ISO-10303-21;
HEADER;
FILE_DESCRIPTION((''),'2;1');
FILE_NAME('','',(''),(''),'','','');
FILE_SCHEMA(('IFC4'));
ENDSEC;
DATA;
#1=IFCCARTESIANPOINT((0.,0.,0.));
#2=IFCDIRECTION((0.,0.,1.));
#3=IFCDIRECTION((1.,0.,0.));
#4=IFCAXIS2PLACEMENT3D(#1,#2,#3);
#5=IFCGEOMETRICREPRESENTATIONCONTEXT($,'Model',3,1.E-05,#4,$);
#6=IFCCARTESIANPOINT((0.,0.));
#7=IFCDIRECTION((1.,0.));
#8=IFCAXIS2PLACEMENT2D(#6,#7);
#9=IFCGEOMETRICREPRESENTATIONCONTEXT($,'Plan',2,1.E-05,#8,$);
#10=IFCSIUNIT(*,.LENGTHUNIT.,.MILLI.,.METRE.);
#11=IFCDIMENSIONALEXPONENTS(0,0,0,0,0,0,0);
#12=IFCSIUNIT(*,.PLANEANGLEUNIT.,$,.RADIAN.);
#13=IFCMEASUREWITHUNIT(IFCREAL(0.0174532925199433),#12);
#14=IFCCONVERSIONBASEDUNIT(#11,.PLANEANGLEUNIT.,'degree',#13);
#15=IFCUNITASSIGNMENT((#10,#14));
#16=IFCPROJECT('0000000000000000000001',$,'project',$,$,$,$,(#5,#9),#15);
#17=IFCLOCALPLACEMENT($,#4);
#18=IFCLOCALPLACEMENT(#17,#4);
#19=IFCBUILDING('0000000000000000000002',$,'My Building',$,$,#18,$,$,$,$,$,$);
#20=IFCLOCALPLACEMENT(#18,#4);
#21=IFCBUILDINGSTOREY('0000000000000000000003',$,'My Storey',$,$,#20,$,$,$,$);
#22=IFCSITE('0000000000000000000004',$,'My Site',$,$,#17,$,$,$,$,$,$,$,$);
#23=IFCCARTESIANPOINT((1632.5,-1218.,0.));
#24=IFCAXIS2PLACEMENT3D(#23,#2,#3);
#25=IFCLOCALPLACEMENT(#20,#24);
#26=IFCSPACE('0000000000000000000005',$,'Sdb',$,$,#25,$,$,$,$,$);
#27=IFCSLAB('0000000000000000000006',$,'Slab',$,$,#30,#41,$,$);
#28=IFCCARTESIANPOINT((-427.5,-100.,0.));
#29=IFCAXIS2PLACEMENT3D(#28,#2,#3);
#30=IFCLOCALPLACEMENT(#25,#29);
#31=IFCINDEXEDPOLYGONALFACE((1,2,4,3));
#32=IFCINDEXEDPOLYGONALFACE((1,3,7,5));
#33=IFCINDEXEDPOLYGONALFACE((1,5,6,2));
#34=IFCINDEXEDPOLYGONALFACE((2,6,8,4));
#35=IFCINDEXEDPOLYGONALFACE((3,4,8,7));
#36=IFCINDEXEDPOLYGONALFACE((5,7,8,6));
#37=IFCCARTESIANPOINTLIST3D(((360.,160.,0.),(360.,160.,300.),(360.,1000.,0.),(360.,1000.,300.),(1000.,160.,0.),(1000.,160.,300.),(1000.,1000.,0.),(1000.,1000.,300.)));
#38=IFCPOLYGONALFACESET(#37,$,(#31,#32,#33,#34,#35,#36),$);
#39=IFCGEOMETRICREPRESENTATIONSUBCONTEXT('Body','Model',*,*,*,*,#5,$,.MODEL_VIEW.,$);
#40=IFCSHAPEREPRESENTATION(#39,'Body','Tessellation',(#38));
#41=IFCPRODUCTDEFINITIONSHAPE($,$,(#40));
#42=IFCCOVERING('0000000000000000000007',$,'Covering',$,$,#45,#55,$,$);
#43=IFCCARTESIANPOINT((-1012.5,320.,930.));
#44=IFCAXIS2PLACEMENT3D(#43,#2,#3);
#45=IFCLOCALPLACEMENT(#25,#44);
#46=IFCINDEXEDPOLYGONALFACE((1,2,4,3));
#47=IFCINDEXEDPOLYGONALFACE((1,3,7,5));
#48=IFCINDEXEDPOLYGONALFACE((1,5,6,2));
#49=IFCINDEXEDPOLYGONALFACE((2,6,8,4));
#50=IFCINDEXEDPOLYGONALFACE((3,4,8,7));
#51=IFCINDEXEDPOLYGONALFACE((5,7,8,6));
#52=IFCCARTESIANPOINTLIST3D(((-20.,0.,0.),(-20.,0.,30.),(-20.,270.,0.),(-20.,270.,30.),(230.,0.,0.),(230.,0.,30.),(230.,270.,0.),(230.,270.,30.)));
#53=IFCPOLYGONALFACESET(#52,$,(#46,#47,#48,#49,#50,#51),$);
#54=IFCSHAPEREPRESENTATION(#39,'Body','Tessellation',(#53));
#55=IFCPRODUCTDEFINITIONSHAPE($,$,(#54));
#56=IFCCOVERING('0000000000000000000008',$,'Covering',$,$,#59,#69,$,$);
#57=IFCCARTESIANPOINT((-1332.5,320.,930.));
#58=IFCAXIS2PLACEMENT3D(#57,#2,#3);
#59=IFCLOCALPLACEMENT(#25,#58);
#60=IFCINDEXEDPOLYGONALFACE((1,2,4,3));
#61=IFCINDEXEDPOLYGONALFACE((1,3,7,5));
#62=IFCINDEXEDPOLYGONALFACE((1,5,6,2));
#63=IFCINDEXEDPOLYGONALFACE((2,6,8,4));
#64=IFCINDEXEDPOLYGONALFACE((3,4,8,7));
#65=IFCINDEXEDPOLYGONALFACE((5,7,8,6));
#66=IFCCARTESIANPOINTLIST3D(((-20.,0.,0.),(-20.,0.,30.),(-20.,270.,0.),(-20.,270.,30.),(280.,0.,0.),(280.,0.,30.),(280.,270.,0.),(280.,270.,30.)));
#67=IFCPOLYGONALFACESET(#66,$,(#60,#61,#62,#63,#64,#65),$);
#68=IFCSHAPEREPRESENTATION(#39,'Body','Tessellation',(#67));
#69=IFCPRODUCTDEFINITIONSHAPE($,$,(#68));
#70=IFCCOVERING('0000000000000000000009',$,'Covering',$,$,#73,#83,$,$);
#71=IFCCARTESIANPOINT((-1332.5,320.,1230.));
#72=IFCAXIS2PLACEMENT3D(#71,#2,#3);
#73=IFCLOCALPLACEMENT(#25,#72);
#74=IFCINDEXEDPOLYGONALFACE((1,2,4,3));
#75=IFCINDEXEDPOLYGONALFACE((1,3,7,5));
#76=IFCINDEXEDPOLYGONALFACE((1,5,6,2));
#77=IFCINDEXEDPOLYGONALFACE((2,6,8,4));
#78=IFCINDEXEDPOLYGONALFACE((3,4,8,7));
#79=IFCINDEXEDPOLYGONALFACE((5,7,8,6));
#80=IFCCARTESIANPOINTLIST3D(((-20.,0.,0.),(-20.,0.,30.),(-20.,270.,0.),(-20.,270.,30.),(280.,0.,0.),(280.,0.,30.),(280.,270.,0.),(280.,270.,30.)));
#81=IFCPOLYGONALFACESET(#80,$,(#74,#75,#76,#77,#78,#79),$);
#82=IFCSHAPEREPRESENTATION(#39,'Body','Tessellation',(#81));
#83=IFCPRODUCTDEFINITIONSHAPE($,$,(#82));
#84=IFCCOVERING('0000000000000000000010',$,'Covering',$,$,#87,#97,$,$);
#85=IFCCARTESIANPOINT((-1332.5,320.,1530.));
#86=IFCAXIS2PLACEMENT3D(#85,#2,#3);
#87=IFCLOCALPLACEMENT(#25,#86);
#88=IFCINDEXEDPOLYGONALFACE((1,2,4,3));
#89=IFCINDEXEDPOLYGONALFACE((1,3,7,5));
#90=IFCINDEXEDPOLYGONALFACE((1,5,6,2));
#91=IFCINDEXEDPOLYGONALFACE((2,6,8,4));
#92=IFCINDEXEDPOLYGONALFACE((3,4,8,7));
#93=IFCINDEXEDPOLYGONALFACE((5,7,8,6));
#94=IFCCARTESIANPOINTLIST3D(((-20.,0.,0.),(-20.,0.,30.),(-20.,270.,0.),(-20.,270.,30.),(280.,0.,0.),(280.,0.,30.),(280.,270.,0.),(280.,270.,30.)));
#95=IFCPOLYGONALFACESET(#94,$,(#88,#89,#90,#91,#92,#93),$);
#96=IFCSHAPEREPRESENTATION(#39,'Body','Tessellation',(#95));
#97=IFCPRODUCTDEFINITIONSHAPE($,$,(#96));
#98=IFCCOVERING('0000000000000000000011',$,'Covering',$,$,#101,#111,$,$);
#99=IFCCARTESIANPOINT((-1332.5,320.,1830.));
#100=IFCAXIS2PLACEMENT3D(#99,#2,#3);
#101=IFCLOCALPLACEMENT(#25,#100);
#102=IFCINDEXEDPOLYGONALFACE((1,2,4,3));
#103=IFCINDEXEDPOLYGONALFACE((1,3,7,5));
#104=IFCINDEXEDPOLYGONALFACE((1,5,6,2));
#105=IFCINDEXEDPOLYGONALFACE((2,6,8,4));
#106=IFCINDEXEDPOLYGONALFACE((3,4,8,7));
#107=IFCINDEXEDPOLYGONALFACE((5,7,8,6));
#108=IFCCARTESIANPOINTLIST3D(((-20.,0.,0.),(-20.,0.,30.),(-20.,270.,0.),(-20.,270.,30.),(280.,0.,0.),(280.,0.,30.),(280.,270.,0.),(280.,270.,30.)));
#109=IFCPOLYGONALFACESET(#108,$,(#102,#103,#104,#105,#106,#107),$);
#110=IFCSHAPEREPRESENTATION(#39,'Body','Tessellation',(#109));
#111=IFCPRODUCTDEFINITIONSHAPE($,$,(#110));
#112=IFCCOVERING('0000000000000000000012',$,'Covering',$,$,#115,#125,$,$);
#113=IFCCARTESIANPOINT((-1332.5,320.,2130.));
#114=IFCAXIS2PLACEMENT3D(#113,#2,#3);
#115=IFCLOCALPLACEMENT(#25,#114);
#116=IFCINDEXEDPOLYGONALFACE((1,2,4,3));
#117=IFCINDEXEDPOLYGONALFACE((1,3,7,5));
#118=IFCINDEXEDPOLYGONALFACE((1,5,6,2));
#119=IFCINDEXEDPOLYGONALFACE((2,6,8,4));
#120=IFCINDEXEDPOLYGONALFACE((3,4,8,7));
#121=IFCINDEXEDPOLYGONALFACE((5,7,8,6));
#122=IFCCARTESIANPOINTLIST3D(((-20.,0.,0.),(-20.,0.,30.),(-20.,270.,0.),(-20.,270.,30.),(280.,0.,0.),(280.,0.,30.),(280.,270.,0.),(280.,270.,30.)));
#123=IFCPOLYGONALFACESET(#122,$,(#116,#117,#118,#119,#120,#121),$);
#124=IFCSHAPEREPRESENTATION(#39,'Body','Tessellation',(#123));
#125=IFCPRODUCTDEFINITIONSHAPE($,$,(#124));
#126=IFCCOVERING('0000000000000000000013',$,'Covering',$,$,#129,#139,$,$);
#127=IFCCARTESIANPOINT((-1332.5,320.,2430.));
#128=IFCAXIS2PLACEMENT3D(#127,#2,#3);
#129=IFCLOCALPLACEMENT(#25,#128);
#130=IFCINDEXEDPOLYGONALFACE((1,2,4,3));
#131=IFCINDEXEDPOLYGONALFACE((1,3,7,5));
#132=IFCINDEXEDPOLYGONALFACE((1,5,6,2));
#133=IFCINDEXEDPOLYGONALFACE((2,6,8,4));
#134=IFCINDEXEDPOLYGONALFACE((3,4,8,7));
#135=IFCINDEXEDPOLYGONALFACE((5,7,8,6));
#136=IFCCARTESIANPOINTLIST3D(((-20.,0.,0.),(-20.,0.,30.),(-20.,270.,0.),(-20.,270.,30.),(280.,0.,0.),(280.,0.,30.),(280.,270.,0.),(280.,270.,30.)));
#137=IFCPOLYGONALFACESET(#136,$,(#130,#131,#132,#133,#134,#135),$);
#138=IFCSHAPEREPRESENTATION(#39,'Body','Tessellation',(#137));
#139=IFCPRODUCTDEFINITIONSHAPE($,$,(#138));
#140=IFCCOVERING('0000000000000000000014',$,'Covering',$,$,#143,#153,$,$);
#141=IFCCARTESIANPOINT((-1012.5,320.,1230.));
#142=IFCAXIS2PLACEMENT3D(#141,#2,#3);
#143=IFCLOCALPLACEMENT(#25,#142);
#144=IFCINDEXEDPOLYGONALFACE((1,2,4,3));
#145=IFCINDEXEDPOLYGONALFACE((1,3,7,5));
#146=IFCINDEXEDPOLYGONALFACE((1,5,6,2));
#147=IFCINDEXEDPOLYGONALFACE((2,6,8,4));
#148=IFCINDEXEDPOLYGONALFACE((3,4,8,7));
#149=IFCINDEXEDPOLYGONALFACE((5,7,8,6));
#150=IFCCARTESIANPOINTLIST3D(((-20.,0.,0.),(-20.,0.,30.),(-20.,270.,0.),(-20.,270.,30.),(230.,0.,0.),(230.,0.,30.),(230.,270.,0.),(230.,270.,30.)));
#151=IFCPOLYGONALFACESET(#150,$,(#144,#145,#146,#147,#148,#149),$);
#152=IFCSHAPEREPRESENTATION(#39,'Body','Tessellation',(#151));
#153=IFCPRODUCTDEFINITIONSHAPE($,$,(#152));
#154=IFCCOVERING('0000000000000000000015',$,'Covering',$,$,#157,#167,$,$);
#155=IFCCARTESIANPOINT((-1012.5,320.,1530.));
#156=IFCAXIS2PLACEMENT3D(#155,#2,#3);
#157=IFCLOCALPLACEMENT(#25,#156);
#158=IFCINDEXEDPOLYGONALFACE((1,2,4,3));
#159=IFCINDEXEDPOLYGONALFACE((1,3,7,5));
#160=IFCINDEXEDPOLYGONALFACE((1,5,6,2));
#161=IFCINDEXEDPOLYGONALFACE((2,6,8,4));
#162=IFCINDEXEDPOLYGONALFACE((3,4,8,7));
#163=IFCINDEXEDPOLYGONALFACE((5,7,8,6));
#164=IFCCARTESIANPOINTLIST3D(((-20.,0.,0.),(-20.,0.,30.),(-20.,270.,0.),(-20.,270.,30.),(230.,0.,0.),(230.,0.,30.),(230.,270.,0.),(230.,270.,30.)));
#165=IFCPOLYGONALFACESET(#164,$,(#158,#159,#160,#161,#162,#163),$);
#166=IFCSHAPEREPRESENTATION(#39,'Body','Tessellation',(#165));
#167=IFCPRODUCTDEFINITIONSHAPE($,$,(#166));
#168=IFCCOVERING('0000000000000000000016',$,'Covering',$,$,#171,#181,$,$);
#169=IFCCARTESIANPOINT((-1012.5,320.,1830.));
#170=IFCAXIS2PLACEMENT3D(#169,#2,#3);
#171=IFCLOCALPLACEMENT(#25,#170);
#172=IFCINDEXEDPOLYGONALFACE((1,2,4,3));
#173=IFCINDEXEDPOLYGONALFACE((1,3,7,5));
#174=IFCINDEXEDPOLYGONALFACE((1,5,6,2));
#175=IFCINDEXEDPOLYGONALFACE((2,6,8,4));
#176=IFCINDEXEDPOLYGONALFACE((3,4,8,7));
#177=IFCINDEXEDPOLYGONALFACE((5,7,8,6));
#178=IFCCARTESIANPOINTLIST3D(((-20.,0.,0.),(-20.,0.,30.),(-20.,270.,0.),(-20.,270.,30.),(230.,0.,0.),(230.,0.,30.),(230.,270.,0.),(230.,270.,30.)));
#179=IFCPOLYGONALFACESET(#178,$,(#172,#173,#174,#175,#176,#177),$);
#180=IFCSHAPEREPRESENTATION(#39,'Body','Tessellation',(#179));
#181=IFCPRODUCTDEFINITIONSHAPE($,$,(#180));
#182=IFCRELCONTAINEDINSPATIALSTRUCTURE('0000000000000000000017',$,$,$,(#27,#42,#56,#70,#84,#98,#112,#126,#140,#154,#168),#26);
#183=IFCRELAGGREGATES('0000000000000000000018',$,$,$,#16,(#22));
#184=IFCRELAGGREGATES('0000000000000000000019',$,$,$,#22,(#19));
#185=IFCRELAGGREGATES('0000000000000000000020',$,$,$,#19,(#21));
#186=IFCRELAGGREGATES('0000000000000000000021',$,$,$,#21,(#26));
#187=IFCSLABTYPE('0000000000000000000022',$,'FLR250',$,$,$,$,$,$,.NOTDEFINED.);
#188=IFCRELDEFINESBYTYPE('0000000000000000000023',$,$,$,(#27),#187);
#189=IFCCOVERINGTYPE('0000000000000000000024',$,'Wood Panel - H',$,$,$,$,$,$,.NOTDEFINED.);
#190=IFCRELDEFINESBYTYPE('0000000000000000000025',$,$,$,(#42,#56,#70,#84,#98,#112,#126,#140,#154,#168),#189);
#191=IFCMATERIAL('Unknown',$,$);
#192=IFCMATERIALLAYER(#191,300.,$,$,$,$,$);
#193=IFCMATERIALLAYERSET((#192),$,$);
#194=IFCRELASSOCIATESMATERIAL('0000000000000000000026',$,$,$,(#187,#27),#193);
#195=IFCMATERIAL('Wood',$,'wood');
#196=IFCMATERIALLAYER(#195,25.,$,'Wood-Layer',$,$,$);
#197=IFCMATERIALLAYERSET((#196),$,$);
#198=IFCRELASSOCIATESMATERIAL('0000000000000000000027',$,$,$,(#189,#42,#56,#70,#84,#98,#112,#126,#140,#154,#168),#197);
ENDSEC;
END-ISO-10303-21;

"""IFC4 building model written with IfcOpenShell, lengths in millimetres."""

from ifc_helpers import new_model, entity, si_unit, converted_unit, frame, origin_with_axes, origin_2d_with_axis, place, context, subcontext, project, spatial, line, indexed_curve, outline, extrude, material, layer, layer_set, layer_usage, type_object, element, save


model = new_model("IFC4")

# Units and contexts
model_context = context("Model", 3, precision=1e-05, world=origin_with_axes())
plan_context = context("Plan", 2, precision=1e-05, world=origin_2d_with_axis())
body_context = subcontext(model_context, "Body", "Model", "MODEL_VIEW")
ifc_project = project(units=[si_unit("LENGTHUNIT", "METRE", prefix="MILLI"), converted_unit("PLANEANGLEUNIT", "degree", entity("IfcReal", 0.0174532925199433), si_unit("PLANEANGLEUNIT", "RADIAN"), dimensions=[0, 0, 0, 0, 0, 0, 0])], contexts=[model_context, plan_context])

# Site, building, storey, space
site_placement = place(None, origin_with_axes())
site = spatial("IfcSite", under=ifc_project, at=site_placement, Name="My Site")
building_placement = place(site_placement, origin_with_axes())
building = spatial("IfcBuilding", under=site, at=building_placement, Name="My Building")
storey_placement = place(building_placement, origin_with_axes())
storey = spatial("IfcBuildingStorey", under=building, at=storey_placement, Name="My Storey")
space_1_placement = place(storey_placement, frame((1632.5, -1218.0, 0.0), z_axis=(0.0, 0.0, 1.0), x_axis=(1.0, 0.0, 0.0)))
space_1 = spatial("IfcSpace", under=storey, at=space_1_placement, Name="Sdb")

# Slab
ifc_material_1 = material(Name="Unknown")
ifc_layer_1 = layer(ifc_material_1, 300.0)
ifc_layer_set_1 = layer_set([ifc_layer_1])
ifc_layer_usage_1 = layer_usage(ifc_layer_set_1, "AXIS3", "POSITIVE", 0.0)
slab_type = type_object("IfcSlabType", Name="FLR250", PredefinedType="NOTDEFINED", material=ifc_layer_set_1)
slab_placement = place(space_1_placement, frame((-427.5, -100.0, 0.0), z_axis=(0.0, 0.0, 1.0), x_axis=(1.0, 0.0, 0.0)))
element("IfcSlab", 1, at=slab_placement, inside=space_1, type_object=slab_type, material=ifc_layer_usage_1, Name="Slab", context=body_context, shape_type="SweptSolid", body=[
    extrude(outline(indexed_curve([(1000.0, 160.0), (360.0, 160.0), (360.0, 1000.0), (1000.0, 1000.0)], segments=[line(4, 1), line(1, 2), line(2, 3), line(3, 4)], self_intersect=False)), None, (0.0, 0.0, 1.0), 300.0),
])

# Coverings
ifc_material_2 = material(Name="Wood", Category="wood")
ifc_layer_2 = layer(ifc_material_2, 25.0, Name="Wood-Layer")
ifc_layer_set_2 = layer_set([ifc_layer_2])
ifc_layer_usage_2 = layer_usage(ifc_layer_set_2, "AXIS3", "POSITIVE", 0.0)
covering_type_1 = type_object("IfcCoveringType", Name="Wood Panel - H", PredefinedType="NOTDEFINED", material=ifc_layer_set_2)
covering_1_placement = place(space_1_placement, frame((-1012.5, 320.0, 930.0), z_axis=(0.0, 0.0, 1.0), x_axis=(1.0, 0.0, 0.0)))
element("IfcCovering", 2, at=covering_1_placement, inside=space_1, type_object=covering_type_1, material=ifc_layer_usage_2, Name="Covering", context=body_context, shape_type="SweptSolid", body=[
    extrude(outline(indexed_curve([(-20.0, 0.0), (-20.0, 270.0), (230.0, 270.0), (230.0, 0.0)], segments=[line(4, 1), line(1, 2), line(2, 3), line(3, 4)], self_intersect=False)), None, (0.0, 0.0, 1.0), 30.0),
])
ifc_layer_usage_3 = layer_usage(ifc_layer_set_2, "AXIS3", "POSITIVE", 0.0)
covering_2_placement = place(space_1_placement, frame((-1332.5, 320.0, 930.0), z_axis=(0.0, 0.0, 1.0), x_axis=(1.0, 0.0, 0.0)))
element("IfcCovering", 3, at=covering_2_placement, inside=space_1, type_object=covering_type_1, material=ifc_layer_usage_3, Name="Covering", context=body_context, shape_type="SweptSolid", body=[
    extrude(outline(indexed_curve([(280.0, 0.0), (-20.0, 0.0), (-20.0, 270.0), (280.0, 270.0)], segments=[line(4, 1), line(1, 2), line(2, 3), line(3, 4)], self_intersect=False)), None, (0.0, 0.0, 1.0), 30.0),
])
ifc_layer_usage_4 = layer_usage(ifc_layer_set_2, "AXIS3", "POSITIVE", 0.0)
covering_3_placement = place(space_1_placement, frame((-1332.5, 320.0, 1230.0), z_axis=(0.0, 0.0, 1.0), x_axis=(1.0, 0.0, 0.0)))
element("IfcCovering", 4, at=covering_3_placement, inside=space_1, type_object=covering_type_1, material=ifc_layer_usage_4, Name="Covering", context=body_context, shape_type="SweptSolid", body=[
    extrude(outline(indexed_curve([(280.0, 0.0), (-20.0, 0.0), (-20.0, 270.0), (280.0, 270.0)], segments=[line(4, 1), line(1, 2), line(2, 3), line(3, 4)], self_intersect=False)), None, (0.0, 0.0, 1.0), 30.0),
])
ifc_layer_usage_5 = layer_usage(ifc_layer_set_2, "AXIS3", "POSITIVE", 0.0)
covering_4_placement = place(space_1_placement, frame((-1332.5, 320.0, 1530.0), z_axis=(0.0, 0.0, 1.0), x_axis=(1.0, 0.0, 0.0)))
element("IfcCovering", 5, at=covering_4_placement, inside=space_1, type_object=covering_type_1, material=ifc_layer_usage_5, Name="Covering", context=body_context, shape_type="SweptSolid", body=[
    extrude(outline(indexed_curve([(280.0, 0.0), (-20.0, 0.0), (-20.0, 270.0), (280.0, 270.0)], segments=[line(4, 1), line(1, 2), line(2, 3), line(3, 4)], self_intersect=False)), None, (0.0, 0.0, 1.0), 30.0),
])
ifc_layer_usage_6 = layer_usage(ifc_layer_set_2, "AXIS3", "POSITIVE", 0.0)
covering_5_placement = place(space_1_placement, frame((-1332.5, 320.0, 1830.0), z_axis=(0.0, 0.0, 1.0), x_axis=(1.0, 0.0, 0.0)))
element("IfcCovering", 6, at=covering_5_placement, inside=space_1, type_object=covering_type_1, material=ifc_layer_usage_6, Name="Covering", context=body_context, shape_type="SweptSolid", body=[
    extrude(outline(indexed_curve([(280.0, 0.0), (-20.0, 0.0), (-20.0, 270.0), (280.0, 270.0)], segments=[line(4, 1), line(1, 2), line(2, 3), line(3, 4)], self_intersect=False)), None, (0.0, 0.0, 1.0), 30.0),
])
ifc_layer_usage_7 = layer_usage(ifc_layer_set_2, "AXIS3", "POSITIVE", 0.0)
covering_6_placement = place(space_1_placement, frame((-1332.5, 320.0, 2130.0), z_axis=(0.0, 0.0, 1.0), x_axis=(1.0, 0.0, 0.0)))
element("IfcCovering", 7, at=covering_6_placement, inside=space_1, type_object=covering_type_1, material=ifc_layer_usage_7, Name="Covering", context=body_context, shape_type="SweptSolid", body=[
    extrude(outline(indexed_curve([(280.0, 0.0), (-20.0, 0.0), (-20.0, 270.0), (280.0, 270.0)], segments=[line(4, 1), line(1, 2), line(2, 3), line(3, 4)], self_intersect=False)), None, (0.0, 0.0, 1.0), 30.0),
])
ifc_layer_usage_8 = layer_usage(ifc_layer_set_2, "AXIS3", "POSITIVE", 0.0)
covering_7_placement = place(space_1_placement, frame((-1332.5, 320.0, 2430.0), z_axis=(0.0, 0.0, 1.0), x_axis=(1.0, 0.0, 0.0)))
element("IfcCovering", 8, at=covering_7_placement, inside=space_1, type_object=covering_type_1, material=ifc_layer_usage_8, Name="Covering", context=body_context, shape_type="SweptSolid", body=[
    extrude(outline(indexed_curve([(280.0, 0.0), (-20.0, 0.0), (-20.0, 270.0), (280.0, 270.0)], segments=[line(4, 1), line(1, 2), line(2, 3), line(3, 4)], self_intersect=False)), None, (0.0, 0.0, 1.0), 30.0),
])
ifc_layer_usage_9 = layer_usage(ifc_layer_set_2, "AXIS3", "POSITIVE", 0.0)
covering_8_placement = place(space_1_placement, frame((-1012.5, 320.0, 1230.0), z_axis=(0.0, 0.0, 1.0), x_axis=(1.0, 0.0, 0.0)))
element("IfcCovering", 9, at=covering_8_placement, inside=space_1, type_object=covering_type_1, material=ifc_layer_usage_9, Name="Covering", context=body_context, shape_type="SweptSolid", body=[
    extrude(outline(indexed_curve([(-20.0, 0.0), (-20.0, 270.0), (230.0, 270.0), (230.0, 0.0)], segments=[line(4, 1), line(1, 2), line(2, 3), line(3, 4)], self_intersect=False)), None, (0.0, 0.0, 1.0), 30.0),
])
ifc_layer_usage_10 = layer_usage(ifc_layer_set_2, "AXIS3", "POSITIVE", 0.0)
covering_9_placement = place(space_1_placement, frame((-1012.5, 320.0, 1530.0), z_axis=(0.0, 0.0, 1.0), x_axis=(1.0, 0.0, 0.0)))
element("IfcCovering", 10, at=covering_9_placement, inside=space_1, type_object=covering_type_1, material=ifc_layer_usage_10, Name="Covering", context=body_context, shape_type="SweptSolid", body=[
    extrude(outline(indexed_curve([(-20.0, 0.0), (-20.0, 270.0), (230.0, 270.0), (230.0, 0.0)], segments=[line(4, 1), line(1, 2), line(2, 3), line(3, 4)], self_intersect=False)), None, (0.0, 0.0, 1.0), 30.0),
])
ifc_layer_usage_11 = layer_usage(ifc_layer_set_2, "AXIS3", "POSITIVE", 0.0)
covering_10_placement = place(space_1_placement, frame((-1012.5, 320.0, 1830.0), z_axis=(0.0, 0.0, 1.0), x_axis=(1.0, 0.0, 0.0)))
element("IfcCovering", 11, at=covering_10_placement, inside=space_1, type_object=covering_type_1, material=ifc_layer_usage_11, Name="Covering", context=body_context, shape_type="SweptSolid", body=[
    extrude(outline(indexed_curve([(-20.0, 0.0), (-20.0, 270.0), (230.0, 270.0), (230.0, 0.0)], segments=[line(4, 1), line(1, 2), line(2, 3), line(3, 4)], self_intersect=False)), None, (0.0, 0.0, 1.0), 30.0),
])

save(model, "model.ifc")
